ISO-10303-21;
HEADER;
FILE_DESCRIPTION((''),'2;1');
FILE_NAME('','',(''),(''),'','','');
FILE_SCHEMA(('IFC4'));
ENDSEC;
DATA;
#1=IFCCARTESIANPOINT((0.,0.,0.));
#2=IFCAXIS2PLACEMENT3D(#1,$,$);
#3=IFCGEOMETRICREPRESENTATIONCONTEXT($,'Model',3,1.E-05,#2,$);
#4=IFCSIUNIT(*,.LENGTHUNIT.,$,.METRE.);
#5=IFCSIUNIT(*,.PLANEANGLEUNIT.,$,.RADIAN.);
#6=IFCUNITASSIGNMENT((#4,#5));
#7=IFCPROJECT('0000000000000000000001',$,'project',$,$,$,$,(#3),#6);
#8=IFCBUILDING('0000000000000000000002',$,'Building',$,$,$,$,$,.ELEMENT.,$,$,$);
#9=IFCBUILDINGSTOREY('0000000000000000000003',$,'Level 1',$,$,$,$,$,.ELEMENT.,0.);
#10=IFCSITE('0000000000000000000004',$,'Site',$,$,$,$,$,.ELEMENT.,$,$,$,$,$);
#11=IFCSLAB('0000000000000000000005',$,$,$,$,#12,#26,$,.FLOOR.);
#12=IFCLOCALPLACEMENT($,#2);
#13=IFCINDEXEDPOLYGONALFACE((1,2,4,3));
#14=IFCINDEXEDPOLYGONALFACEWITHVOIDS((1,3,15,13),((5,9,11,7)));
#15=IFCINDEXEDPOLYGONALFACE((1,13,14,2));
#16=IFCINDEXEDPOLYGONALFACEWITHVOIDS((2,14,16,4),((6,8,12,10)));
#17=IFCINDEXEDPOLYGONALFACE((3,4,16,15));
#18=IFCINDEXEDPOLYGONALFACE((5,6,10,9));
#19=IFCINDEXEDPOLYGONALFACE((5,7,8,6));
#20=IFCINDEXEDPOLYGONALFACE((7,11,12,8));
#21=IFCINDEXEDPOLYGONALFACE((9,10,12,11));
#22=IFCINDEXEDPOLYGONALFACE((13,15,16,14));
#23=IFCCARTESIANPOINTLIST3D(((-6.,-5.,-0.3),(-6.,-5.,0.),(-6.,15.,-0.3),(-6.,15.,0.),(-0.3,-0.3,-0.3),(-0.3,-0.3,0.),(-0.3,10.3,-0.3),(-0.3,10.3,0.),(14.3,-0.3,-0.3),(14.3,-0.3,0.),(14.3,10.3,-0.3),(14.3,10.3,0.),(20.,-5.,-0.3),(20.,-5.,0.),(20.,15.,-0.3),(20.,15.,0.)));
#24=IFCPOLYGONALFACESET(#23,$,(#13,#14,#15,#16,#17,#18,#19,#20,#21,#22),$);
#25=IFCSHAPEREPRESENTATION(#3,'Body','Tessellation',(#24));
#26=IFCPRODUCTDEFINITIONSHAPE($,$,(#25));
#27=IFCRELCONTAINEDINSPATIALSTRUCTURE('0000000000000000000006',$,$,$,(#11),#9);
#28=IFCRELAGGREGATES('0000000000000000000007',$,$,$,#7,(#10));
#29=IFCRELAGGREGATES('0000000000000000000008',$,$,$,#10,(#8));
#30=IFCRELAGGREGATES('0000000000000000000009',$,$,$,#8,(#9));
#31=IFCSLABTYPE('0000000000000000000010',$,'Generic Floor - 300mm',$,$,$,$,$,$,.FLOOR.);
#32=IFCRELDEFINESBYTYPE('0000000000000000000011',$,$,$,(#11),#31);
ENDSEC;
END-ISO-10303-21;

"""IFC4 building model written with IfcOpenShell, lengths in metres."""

from ifc_helpers import new_model, si_unit, frame, origin, place, context, project, spatial, polyline, outline, extrude, type_object, element, save


model = new_model("IFC4")

# Units and contexts
model_context = context("Model", 3, precision=1e-05, world=origin())
ifc_project = project(units=[si_unit("LENGTHUNIT", "METRE"), si_unit("PLANEANGLEUNIT", "RADIAN")], contexts=[model_context])

# Site, building, storey
site = spatial("IfcSite", under=ifc_project, Name="Site", CompositionType="ELEMENT")
building = spatial("IfcBuilding", under=site, Name="Building", CompositionType="ELEMENT")
storey = spatial("IfcBuildingStorey", under=building, Name="Level 1", CompositionType="ELEMENT", Elevation=0.0)

# Slab, opening
slab_type = type_object("IfcSlabType", Name="Generic Floor - 300mm", PredefinedType="FLOOR")
slab_placement = place(None, origin())
slab = element("IfcSlab", 1, at=slab_placement, inside=storey, type_object=slab_type, PredefinedType="FLOOR", context=model_context, shape_type="SweptSolid", body=[
    extrude(outline(polyline([(-6.0, -5.0), (20.0, -5.0), (20.0, 15.0), (-6.0, 15.0), (-6.0, -5.0)])), origin(), (0.0, 0.0, -1.0), 0.3),
])
opening_placement = place(None, frame((0.0, 0.0, 0.001)))
element("IfcOpeningElement", 2, at=opening_placement, cuts=slab, PredefinedType="OPENING", context=model_context, shape_type="SweptSolid", body=[
    extrude(outline(polyline([(-0.3, 10.3), (-0.3, -0.3), (14.3, -0.3), (14.3, 10.3), (-0.3, 10.3)])), origin(), (0.0, 0.0, -1.0), 0.302),
])

save(model, "model.ifc")
